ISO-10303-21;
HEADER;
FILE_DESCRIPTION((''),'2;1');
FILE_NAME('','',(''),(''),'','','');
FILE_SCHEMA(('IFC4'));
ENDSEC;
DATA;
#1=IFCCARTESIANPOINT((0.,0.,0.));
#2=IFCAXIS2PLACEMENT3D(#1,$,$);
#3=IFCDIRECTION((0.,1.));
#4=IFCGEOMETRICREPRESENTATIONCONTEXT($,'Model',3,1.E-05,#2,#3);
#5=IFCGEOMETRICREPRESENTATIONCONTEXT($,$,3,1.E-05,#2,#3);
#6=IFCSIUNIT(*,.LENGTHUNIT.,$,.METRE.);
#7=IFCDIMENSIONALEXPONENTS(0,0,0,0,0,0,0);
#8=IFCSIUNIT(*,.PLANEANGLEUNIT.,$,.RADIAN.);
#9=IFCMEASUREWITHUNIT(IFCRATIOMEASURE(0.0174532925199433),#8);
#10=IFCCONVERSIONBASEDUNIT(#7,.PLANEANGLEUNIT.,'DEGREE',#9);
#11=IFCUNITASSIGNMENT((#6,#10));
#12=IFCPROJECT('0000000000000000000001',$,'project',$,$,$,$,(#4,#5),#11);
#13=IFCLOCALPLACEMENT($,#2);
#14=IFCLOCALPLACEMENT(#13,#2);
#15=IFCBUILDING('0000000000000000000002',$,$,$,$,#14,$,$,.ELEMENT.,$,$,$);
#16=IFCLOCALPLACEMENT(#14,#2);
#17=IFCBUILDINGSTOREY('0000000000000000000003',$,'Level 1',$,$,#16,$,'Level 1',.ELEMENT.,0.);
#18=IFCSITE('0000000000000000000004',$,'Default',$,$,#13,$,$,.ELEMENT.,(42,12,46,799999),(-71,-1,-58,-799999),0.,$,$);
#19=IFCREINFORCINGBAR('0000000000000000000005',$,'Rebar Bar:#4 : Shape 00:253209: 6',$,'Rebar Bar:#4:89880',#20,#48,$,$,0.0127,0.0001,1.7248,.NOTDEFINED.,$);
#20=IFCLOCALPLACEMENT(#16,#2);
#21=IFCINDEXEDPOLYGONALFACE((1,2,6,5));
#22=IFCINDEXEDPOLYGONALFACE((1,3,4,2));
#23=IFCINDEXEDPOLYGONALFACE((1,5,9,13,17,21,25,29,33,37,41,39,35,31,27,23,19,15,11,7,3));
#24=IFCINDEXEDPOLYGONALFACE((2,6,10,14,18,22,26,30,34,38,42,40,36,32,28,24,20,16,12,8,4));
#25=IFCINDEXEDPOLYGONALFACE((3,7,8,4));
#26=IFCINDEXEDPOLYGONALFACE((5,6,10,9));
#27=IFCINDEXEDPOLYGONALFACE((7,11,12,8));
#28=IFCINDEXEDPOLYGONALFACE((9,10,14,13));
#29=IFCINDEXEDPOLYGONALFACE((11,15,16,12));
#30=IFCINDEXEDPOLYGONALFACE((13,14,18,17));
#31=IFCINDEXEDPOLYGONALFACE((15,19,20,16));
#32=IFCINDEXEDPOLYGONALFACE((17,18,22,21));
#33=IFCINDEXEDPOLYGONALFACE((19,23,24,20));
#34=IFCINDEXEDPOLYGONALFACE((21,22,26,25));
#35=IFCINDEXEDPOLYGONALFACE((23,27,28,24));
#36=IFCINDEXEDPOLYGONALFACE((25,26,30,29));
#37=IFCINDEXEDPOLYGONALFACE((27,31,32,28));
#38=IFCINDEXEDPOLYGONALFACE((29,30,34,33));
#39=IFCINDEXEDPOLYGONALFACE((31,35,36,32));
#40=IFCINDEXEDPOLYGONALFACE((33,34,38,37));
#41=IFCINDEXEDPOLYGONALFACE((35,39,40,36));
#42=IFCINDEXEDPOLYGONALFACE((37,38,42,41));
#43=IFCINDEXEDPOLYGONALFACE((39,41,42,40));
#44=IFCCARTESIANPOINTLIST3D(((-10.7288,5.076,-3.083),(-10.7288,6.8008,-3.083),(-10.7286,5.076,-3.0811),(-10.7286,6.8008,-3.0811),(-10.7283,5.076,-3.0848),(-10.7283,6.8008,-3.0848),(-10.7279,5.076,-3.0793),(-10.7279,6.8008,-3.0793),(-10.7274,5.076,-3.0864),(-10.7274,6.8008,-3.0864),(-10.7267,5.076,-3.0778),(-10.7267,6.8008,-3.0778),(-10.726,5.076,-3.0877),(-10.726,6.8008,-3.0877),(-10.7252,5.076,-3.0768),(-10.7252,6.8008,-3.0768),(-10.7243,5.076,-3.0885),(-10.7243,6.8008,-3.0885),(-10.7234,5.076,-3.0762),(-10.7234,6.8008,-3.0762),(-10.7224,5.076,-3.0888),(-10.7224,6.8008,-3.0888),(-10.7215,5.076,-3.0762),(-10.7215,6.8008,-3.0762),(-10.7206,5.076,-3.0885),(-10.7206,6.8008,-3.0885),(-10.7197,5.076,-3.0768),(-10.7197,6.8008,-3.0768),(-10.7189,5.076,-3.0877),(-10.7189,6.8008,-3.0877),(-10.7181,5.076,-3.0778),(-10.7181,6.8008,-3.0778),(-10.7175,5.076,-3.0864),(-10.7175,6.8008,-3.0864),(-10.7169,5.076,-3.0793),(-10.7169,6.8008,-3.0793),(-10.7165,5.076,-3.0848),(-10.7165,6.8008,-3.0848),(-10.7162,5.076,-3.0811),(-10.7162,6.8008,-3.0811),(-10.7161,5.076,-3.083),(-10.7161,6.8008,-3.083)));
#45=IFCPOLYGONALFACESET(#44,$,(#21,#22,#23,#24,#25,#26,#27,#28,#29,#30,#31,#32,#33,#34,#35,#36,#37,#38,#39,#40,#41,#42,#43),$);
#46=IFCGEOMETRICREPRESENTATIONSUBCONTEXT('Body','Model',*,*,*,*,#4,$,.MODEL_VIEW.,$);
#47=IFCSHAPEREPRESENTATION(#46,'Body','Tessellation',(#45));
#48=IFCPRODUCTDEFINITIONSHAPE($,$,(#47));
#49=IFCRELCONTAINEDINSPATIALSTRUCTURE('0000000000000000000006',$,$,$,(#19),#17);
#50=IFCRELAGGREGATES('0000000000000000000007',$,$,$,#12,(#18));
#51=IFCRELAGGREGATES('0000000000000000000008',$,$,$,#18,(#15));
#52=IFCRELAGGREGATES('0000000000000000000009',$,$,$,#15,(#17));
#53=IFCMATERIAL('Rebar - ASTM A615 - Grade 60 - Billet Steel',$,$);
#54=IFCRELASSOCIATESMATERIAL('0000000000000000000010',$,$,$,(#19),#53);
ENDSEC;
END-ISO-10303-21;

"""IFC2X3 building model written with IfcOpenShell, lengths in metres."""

from ifc_helpers import new_model, entity, si_unit, converted_unit, direction, origin, place, context, subcontext, project, spatial, material, element, save


model = new_model("IFC2X3")

# Units and contexts
model_context = context("Model", 3, precision=1e-05, world=origin(), true_north=direction((0.0, 1.0)))
context_of_model = context(None, 3, precision=1e-05, world=origin(), true_north=direction((0.0, 1.0)))
body_context = subcontext(model_context, "Body", "Model", "MODEL_VIEW")
ifc_project = project(units=[si_unit("LENGTHUNIT", "METRE"), converted_unit("PLANEANGLEUNIT", "DEGREE", entity("IfcRatioMeasure", 0.0174532925199433), si_unit("PLANEANGLEUNIT", "RADIAN"), dimensions=[0, 0, 0, 0, 0, 0, 0])], contexts=[model_context, context_of_model])

# Site, building, storey
site_placement = place(None, origin())
site = spatial("IfcSite", under=ifc_project, at=site_placement, Name="Default", CompositionType="ELEMENT", RefLatitude=(42, 12, 46, 799999), RefLongitude=(-71, -1, -58, -799999), RefElevation=0.0)
building_placement = place(site_placement, origin())
building = spatial("IfcBuilding", under=site, at=building_placement, CompositionType="ELEMENT")
storey_placement = place(building_placement, origin())
storey = spatial("IfcBuildingStorey", under=building, at=storey_placement, Name="Level 1", LongName="Level 1", CompositionType="ELEMENT", Elevation=0.0)

# Reinforcing bar
ifc_material = material(Name="Rebar - ASTM A615 - Grade 60 - Billet Steel")
reinforcing_bar_1_placement = place(storey_placement, origin())
element("IfcReinforcingBar", 1, at=reinforcing_bar_1_placement, inside=storey, material=ifc_material, Name="Rebar Bar:#4 : Shape 00:253209: 6", ObjectType="Rebar Bar:#4:89880", BarLength=1.7248, BarRole="NOTDEFINED", CrossSectionArea=0.0001, NominalDiameter=0.0127, context=body_context, shape_type="AdvancedSweptSolid", body=[
    entity("IfcSweptDiskSolid", entity("IfcCompositeCurve", [entity("IfcCompositeCurveSegment", "CONTINUOUS", True, entity("IfcPolyline", [entity("IfcCartesianPoint", [-10.7224, 6.8008, -3.0825]), entity("IfcCartesianPoint", [-10.7224, 5.076, -3.0825])]))], False), 0.0063, None, 0.0, 1.0),
])

save(model, "model.ifc")
